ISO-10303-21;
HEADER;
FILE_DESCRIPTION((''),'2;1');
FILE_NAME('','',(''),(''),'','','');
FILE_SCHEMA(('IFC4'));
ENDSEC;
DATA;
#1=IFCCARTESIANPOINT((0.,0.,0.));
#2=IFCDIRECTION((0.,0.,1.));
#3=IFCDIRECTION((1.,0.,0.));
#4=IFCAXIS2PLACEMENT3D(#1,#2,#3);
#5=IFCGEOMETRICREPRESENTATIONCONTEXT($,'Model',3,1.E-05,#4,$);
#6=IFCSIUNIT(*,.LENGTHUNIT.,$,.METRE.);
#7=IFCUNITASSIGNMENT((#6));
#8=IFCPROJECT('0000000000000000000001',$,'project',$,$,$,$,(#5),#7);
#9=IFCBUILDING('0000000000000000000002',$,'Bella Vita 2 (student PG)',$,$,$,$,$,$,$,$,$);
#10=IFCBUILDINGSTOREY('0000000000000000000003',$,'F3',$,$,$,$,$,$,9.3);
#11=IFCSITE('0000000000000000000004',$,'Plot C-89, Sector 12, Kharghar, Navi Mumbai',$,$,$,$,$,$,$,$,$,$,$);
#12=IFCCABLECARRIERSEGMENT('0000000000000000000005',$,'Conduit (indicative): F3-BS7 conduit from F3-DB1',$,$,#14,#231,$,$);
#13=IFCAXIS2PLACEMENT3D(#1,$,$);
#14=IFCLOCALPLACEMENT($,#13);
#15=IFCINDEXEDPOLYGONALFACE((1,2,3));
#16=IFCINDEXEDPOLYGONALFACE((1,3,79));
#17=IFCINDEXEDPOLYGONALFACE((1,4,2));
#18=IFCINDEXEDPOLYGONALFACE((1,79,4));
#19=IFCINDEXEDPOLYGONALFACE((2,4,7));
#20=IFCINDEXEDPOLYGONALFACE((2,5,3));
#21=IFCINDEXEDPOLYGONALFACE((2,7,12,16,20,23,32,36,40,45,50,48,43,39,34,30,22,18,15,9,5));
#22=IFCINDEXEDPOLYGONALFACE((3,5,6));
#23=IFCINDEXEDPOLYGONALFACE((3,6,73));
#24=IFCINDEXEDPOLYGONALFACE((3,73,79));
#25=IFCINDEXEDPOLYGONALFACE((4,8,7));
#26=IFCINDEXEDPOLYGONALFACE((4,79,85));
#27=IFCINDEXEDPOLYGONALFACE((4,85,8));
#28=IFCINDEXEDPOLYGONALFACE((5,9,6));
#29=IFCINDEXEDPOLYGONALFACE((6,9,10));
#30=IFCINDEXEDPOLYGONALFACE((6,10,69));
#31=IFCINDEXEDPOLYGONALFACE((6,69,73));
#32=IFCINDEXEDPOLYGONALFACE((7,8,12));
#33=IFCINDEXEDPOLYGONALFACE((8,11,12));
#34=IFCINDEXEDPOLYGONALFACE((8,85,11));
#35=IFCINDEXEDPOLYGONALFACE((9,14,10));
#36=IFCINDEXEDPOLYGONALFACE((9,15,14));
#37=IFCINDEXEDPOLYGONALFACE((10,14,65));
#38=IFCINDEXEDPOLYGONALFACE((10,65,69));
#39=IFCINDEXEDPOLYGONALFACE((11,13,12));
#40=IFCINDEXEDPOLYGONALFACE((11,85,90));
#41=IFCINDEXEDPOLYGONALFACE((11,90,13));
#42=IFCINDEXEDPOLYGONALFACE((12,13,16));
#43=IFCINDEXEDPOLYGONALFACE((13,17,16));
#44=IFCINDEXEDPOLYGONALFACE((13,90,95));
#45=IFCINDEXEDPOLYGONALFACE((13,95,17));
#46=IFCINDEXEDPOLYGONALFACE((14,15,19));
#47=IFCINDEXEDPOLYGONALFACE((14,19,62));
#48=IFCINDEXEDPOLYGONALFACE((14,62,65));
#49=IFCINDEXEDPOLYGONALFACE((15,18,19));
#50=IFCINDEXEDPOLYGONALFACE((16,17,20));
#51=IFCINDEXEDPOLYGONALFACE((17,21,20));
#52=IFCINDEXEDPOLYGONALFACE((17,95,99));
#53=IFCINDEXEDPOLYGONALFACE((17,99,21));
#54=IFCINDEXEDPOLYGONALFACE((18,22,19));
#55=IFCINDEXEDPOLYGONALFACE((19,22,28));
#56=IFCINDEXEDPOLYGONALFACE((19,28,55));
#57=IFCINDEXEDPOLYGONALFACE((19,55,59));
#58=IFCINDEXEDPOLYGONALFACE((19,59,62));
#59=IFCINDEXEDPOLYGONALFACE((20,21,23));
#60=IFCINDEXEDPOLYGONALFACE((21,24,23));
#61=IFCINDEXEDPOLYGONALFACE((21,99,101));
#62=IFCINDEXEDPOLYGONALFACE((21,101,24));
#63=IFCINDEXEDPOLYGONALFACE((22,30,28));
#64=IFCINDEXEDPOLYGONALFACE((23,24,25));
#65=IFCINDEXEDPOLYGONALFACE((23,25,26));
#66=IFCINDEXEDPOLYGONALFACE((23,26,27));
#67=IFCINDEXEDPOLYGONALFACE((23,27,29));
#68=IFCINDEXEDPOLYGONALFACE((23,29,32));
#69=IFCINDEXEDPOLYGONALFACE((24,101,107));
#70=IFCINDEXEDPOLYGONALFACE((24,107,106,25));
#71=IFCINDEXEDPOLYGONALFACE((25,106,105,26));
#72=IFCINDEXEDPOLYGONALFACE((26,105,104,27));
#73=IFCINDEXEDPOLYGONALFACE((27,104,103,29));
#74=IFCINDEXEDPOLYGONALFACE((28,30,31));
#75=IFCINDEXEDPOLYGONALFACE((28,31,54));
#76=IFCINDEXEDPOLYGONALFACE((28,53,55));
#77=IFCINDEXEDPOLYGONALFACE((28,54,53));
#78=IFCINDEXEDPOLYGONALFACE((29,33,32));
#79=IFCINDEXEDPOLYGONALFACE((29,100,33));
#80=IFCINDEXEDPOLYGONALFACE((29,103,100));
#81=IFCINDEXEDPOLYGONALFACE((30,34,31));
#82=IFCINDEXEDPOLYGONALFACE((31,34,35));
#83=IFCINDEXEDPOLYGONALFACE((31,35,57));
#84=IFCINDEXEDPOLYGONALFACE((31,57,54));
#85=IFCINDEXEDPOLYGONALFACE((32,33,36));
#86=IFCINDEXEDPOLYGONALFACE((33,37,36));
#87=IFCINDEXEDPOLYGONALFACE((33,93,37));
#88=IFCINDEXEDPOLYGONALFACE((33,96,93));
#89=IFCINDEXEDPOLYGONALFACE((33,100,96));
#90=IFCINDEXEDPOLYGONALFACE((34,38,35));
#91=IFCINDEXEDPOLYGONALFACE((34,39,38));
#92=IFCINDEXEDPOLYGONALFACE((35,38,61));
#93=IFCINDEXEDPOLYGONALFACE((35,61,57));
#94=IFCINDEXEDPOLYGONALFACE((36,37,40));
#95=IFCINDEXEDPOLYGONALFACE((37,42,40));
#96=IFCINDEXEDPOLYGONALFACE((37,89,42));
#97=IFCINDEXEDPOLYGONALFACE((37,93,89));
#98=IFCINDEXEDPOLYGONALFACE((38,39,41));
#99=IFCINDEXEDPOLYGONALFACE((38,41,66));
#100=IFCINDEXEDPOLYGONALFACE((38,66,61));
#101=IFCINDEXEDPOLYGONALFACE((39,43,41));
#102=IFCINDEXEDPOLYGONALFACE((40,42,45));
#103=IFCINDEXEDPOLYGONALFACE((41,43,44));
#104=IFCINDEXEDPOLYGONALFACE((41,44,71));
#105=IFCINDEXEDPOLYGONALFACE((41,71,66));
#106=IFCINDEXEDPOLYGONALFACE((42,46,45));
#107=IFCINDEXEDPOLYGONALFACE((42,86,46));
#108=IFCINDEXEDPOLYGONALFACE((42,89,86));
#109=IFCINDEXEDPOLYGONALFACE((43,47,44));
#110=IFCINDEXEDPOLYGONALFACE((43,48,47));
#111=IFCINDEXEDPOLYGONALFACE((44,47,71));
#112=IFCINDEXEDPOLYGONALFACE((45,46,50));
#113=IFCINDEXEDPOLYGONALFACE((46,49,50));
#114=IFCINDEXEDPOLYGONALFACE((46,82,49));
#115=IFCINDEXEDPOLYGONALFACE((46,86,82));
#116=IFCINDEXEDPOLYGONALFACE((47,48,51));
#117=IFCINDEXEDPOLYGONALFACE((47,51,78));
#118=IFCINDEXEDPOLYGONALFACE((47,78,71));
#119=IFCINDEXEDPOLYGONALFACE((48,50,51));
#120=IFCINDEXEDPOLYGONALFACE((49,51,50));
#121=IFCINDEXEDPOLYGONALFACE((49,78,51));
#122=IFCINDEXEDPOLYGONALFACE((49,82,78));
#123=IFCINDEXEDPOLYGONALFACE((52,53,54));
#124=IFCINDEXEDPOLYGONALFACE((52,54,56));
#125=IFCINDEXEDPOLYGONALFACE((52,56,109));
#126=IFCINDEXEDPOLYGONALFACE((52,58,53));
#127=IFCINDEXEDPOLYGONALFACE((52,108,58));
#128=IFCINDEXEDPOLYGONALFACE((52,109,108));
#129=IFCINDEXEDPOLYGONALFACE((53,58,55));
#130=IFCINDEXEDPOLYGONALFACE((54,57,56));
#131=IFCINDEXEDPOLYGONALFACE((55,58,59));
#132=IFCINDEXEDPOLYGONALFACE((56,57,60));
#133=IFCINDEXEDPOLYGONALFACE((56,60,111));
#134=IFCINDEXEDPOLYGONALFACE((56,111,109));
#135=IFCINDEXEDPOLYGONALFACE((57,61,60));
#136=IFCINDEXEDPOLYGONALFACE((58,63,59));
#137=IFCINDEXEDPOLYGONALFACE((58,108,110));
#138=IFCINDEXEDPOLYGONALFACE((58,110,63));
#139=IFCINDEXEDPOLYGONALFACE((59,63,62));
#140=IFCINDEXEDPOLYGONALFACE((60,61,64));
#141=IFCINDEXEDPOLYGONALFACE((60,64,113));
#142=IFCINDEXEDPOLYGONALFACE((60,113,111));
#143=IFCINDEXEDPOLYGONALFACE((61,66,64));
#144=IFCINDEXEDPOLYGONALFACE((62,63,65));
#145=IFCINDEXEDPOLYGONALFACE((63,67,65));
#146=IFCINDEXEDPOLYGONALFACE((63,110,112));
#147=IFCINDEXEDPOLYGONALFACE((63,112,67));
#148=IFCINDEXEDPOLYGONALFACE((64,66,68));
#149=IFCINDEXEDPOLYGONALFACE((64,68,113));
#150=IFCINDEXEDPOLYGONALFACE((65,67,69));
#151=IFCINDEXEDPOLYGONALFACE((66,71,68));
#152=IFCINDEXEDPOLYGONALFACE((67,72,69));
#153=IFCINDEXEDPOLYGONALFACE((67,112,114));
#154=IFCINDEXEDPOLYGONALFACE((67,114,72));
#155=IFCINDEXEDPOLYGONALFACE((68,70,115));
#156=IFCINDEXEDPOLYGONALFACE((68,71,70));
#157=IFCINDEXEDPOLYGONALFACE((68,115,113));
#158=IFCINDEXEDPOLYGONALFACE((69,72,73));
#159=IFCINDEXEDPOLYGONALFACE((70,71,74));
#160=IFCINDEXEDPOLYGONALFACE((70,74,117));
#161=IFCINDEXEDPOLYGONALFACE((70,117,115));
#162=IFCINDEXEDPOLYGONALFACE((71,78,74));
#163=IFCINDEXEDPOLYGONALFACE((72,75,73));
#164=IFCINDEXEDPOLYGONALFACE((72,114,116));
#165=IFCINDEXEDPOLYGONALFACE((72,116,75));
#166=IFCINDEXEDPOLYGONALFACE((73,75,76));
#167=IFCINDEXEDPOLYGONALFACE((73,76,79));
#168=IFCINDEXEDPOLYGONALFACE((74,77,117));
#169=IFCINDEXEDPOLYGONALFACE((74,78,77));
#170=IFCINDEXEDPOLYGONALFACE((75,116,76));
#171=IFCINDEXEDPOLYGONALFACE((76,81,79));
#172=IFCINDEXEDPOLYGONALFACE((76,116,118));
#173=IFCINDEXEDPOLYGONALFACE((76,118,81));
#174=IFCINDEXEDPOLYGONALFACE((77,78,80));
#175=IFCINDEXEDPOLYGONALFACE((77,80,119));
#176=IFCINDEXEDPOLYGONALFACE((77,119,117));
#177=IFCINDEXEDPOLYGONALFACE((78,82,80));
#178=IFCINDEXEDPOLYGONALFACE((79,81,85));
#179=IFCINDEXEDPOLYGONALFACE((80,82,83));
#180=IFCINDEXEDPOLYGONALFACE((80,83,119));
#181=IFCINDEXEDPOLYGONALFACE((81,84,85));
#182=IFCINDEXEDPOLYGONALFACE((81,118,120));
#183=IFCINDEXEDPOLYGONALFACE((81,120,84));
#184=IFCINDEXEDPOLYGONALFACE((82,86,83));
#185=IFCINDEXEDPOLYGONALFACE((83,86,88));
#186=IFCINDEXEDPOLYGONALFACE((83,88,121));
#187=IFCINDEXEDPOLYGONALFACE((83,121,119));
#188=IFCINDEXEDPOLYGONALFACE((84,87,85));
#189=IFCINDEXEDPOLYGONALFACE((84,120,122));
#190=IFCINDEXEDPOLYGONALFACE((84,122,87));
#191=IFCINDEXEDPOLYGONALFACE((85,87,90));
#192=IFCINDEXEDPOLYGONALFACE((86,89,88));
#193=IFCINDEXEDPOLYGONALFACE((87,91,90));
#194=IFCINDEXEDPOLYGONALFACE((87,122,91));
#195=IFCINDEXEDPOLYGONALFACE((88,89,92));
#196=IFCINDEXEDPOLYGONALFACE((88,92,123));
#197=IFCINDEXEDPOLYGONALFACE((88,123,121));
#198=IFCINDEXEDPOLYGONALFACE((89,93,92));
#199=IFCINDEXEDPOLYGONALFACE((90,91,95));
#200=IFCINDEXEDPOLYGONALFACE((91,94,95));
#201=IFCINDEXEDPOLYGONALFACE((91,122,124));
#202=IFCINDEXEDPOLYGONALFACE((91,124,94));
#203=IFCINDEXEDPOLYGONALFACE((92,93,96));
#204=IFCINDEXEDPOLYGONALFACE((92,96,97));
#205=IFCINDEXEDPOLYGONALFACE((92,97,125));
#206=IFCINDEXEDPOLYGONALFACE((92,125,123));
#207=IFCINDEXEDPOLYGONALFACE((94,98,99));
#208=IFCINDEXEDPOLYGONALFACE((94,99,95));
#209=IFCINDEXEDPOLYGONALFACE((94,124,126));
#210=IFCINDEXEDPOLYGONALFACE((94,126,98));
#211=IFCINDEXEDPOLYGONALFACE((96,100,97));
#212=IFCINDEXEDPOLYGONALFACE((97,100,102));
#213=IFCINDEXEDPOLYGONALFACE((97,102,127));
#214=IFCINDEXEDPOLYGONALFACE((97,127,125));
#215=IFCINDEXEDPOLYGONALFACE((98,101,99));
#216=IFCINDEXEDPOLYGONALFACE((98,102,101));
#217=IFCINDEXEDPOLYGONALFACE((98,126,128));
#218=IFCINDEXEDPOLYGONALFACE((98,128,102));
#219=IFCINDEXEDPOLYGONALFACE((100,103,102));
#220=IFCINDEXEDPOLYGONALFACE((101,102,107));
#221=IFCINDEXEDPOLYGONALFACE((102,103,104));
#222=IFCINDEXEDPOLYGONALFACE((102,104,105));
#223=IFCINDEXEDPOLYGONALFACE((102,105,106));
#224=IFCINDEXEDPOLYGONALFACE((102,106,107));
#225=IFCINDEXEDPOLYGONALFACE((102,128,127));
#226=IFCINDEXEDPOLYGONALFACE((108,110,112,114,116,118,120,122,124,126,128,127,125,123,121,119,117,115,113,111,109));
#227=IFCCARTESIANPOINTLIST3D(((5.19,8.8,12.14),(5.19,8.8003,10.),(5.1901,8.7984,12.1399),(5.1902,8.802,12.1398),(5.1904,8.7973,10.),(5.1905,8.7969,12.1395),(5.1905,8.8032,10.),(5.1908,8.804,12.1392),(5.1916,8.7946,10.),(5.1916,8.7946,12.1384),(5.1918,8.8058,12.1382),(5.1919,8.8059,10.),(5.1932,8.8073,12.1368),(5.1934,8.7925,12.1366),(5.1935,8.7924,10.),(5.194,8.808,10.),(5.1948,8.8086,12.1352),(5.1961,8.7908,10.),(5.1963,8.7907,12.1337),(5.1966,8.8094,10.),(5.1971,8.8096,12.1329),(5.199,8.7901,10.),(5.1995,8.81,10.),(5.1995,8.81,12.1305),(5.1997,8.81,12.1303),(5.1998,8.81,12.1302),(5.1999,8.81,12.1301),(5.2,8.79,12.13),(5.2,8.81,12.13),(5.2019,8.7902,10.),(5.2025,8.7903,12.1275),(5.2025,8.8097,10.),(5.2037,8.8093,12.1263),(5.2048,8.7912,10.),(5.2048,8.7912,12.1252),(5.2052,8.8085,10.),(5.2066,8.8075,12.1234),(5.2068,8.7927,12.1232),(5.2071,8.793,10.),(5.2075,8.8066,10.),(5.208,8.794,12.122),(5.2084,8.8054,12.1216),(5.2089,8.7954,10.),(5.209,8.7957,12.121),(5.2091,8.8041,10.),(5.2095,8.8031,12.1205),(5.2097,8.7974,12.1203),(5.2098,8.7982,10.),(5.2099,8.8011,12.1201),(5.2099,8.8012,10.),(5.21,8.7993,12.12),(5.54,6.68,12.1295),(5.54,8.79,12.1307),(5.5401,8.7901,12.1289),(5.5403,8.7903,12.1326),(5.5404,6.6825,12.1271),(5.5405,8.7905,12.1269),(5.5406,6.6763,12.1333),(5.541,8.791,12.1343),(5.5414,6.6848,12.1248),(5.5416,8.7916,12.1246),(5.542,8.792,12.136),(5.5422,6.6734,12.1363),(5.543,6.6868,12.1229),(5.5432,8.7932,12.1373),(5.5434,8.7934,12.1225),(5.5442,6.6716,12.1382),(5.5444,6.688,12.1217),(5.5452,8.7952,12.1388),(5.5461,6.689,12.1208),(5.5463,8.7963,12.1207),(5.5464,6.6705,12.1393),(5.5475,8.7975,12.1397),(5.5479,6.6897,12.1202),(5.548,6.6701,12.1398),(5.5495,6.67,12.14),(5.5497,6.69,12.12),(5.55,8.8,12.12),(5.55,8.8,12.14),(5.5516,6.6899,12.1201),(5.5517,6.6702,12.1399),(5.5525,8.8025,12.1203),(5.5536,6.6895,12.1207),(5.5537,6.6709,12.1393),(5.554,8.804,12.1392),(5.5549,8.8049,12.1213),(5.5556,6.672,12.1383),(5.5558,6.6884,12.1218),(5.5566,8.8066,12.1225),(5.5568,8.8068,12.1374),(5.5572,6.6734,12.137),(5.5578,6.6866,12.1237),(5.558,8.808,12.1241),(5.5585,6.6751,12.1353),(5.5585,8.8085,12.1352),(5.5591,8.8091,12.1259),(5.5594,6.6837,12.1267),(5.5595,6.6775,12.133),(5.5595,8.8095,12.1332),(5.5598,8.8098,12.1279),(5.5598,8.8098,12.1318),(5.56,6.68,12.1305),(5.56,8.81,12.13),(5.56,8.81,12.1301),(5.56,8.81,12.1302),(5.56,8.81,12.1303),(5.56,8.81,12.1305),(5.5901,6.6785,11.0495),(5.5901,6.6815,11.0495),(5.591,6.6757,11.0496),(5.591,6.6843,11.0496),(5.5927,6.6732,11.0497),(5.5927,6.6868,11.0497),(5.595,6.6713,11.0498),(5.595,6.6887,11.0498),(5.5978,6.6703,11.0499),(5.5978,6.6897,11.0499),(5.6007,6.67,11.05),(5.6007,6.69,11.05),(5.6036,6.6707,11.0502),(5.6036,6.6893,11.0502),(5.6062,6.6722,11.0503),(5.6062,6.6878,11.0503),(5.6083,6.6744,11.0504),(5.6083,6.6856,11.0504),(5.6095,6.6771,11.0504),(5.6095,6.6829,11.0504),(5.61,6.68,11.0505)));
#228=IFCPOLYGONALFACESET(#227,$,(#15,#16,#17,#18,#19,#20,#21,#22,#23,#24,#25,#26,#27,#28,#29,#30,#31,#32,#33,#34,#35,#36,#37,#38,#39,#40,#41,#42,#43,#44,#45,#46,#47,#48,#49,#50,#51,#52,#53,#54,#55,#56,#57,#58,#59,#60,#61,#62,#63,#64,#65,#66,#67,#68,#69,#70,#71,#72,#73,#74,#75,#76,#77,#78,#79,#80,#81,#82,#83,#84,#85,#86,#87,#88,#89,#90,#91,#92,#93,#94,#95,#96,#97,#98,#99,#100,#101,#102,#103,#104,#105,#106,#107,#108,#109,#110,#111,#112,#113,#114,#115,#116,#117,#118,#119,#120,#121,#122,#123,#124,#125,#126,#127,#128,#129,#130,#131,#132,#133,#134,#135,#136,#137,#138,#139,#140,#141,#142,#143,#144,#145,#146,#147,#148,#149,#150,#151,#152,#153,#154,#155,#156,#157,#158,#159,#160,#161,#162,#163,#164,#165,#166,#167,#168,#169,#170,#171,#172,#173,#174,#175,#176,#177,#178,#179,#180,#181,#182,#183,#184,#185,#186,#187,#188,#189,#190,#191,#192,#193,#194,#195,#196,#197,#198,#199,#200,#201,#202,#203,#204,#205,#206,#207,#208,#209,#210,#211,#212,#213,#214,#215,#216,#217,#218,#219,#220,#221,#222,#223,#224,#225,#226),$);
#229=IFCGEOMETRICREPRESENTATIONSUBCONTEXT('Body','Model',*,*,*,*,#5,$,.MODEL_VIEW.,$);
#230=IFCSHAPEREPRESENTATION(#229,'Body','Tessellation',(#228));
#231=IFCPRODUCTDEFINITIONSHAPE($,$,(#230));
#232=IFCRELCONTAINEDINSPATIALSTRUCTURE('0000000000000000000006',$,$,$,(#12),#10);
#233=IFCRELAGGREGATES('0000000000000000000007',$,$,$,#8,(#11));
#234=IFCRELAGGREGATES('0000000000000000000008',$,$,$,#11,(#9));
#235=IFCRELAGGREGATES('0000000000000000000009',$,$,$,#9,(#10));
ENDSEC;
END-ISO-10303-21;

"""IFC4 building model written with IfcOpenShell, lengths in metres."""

from ifc_helpers import new_model, entity, si_unit, origin, origin_with_axes, place, context, subcontext, project, spatial, element, save


model = new_model("IFC4")

# Units and contexts
model_context = context("Model", 3, precision=1e-05, world=origin_with_axes())
body_context = subcontext(model_context, "Body", "Model", "MODEL_VIEW")
ifc_project = project(units=[si_unit("LENGTHUNIT", "METRE")], contexts=[model_context])

# Site, building, storey
site = spatial("IfcSite", under=ifc_project, Name="Plot C-89, Sector 12, Kharghar, Navi Mumbai")
building = spatial("IfcBuilding", under=site, Name="Bella Vita 2 (student PG)")
storey = spatial("IfcBuildingStorey", under=building, Name="F3", Elevation=9.3)

# Cable carrier segment
cable_carrier_segment_1_placement = place(None, origin())
element("IfcCableCarrierSegment", 1, at=cable_carrier_segment_1_placement, inside=storey, Name="Conduit (indicative): F3-BS7 conduit from F3-DB1", context=body_context, shape_type="AdvancedSweptSolid", body=[
    entity("IfcSweptDiskSolid", entity("IfcPolyline", [entity("IfcCartesianPoint", [5.6, 6.68, 11.05]), entity("IfcCartesianPoint", [5.55, 6.68, 12.13]), entity("IfcCartesianPoint", [5.55, 8.8, 12.13]), entity("IfcCartesianPoint", [5.2, 8.8, 12.13]), entity("IfcCartesianPoint", [5.2, 8.8, 10.0])]), 0.01),
])

save(model, "model.ifc")
